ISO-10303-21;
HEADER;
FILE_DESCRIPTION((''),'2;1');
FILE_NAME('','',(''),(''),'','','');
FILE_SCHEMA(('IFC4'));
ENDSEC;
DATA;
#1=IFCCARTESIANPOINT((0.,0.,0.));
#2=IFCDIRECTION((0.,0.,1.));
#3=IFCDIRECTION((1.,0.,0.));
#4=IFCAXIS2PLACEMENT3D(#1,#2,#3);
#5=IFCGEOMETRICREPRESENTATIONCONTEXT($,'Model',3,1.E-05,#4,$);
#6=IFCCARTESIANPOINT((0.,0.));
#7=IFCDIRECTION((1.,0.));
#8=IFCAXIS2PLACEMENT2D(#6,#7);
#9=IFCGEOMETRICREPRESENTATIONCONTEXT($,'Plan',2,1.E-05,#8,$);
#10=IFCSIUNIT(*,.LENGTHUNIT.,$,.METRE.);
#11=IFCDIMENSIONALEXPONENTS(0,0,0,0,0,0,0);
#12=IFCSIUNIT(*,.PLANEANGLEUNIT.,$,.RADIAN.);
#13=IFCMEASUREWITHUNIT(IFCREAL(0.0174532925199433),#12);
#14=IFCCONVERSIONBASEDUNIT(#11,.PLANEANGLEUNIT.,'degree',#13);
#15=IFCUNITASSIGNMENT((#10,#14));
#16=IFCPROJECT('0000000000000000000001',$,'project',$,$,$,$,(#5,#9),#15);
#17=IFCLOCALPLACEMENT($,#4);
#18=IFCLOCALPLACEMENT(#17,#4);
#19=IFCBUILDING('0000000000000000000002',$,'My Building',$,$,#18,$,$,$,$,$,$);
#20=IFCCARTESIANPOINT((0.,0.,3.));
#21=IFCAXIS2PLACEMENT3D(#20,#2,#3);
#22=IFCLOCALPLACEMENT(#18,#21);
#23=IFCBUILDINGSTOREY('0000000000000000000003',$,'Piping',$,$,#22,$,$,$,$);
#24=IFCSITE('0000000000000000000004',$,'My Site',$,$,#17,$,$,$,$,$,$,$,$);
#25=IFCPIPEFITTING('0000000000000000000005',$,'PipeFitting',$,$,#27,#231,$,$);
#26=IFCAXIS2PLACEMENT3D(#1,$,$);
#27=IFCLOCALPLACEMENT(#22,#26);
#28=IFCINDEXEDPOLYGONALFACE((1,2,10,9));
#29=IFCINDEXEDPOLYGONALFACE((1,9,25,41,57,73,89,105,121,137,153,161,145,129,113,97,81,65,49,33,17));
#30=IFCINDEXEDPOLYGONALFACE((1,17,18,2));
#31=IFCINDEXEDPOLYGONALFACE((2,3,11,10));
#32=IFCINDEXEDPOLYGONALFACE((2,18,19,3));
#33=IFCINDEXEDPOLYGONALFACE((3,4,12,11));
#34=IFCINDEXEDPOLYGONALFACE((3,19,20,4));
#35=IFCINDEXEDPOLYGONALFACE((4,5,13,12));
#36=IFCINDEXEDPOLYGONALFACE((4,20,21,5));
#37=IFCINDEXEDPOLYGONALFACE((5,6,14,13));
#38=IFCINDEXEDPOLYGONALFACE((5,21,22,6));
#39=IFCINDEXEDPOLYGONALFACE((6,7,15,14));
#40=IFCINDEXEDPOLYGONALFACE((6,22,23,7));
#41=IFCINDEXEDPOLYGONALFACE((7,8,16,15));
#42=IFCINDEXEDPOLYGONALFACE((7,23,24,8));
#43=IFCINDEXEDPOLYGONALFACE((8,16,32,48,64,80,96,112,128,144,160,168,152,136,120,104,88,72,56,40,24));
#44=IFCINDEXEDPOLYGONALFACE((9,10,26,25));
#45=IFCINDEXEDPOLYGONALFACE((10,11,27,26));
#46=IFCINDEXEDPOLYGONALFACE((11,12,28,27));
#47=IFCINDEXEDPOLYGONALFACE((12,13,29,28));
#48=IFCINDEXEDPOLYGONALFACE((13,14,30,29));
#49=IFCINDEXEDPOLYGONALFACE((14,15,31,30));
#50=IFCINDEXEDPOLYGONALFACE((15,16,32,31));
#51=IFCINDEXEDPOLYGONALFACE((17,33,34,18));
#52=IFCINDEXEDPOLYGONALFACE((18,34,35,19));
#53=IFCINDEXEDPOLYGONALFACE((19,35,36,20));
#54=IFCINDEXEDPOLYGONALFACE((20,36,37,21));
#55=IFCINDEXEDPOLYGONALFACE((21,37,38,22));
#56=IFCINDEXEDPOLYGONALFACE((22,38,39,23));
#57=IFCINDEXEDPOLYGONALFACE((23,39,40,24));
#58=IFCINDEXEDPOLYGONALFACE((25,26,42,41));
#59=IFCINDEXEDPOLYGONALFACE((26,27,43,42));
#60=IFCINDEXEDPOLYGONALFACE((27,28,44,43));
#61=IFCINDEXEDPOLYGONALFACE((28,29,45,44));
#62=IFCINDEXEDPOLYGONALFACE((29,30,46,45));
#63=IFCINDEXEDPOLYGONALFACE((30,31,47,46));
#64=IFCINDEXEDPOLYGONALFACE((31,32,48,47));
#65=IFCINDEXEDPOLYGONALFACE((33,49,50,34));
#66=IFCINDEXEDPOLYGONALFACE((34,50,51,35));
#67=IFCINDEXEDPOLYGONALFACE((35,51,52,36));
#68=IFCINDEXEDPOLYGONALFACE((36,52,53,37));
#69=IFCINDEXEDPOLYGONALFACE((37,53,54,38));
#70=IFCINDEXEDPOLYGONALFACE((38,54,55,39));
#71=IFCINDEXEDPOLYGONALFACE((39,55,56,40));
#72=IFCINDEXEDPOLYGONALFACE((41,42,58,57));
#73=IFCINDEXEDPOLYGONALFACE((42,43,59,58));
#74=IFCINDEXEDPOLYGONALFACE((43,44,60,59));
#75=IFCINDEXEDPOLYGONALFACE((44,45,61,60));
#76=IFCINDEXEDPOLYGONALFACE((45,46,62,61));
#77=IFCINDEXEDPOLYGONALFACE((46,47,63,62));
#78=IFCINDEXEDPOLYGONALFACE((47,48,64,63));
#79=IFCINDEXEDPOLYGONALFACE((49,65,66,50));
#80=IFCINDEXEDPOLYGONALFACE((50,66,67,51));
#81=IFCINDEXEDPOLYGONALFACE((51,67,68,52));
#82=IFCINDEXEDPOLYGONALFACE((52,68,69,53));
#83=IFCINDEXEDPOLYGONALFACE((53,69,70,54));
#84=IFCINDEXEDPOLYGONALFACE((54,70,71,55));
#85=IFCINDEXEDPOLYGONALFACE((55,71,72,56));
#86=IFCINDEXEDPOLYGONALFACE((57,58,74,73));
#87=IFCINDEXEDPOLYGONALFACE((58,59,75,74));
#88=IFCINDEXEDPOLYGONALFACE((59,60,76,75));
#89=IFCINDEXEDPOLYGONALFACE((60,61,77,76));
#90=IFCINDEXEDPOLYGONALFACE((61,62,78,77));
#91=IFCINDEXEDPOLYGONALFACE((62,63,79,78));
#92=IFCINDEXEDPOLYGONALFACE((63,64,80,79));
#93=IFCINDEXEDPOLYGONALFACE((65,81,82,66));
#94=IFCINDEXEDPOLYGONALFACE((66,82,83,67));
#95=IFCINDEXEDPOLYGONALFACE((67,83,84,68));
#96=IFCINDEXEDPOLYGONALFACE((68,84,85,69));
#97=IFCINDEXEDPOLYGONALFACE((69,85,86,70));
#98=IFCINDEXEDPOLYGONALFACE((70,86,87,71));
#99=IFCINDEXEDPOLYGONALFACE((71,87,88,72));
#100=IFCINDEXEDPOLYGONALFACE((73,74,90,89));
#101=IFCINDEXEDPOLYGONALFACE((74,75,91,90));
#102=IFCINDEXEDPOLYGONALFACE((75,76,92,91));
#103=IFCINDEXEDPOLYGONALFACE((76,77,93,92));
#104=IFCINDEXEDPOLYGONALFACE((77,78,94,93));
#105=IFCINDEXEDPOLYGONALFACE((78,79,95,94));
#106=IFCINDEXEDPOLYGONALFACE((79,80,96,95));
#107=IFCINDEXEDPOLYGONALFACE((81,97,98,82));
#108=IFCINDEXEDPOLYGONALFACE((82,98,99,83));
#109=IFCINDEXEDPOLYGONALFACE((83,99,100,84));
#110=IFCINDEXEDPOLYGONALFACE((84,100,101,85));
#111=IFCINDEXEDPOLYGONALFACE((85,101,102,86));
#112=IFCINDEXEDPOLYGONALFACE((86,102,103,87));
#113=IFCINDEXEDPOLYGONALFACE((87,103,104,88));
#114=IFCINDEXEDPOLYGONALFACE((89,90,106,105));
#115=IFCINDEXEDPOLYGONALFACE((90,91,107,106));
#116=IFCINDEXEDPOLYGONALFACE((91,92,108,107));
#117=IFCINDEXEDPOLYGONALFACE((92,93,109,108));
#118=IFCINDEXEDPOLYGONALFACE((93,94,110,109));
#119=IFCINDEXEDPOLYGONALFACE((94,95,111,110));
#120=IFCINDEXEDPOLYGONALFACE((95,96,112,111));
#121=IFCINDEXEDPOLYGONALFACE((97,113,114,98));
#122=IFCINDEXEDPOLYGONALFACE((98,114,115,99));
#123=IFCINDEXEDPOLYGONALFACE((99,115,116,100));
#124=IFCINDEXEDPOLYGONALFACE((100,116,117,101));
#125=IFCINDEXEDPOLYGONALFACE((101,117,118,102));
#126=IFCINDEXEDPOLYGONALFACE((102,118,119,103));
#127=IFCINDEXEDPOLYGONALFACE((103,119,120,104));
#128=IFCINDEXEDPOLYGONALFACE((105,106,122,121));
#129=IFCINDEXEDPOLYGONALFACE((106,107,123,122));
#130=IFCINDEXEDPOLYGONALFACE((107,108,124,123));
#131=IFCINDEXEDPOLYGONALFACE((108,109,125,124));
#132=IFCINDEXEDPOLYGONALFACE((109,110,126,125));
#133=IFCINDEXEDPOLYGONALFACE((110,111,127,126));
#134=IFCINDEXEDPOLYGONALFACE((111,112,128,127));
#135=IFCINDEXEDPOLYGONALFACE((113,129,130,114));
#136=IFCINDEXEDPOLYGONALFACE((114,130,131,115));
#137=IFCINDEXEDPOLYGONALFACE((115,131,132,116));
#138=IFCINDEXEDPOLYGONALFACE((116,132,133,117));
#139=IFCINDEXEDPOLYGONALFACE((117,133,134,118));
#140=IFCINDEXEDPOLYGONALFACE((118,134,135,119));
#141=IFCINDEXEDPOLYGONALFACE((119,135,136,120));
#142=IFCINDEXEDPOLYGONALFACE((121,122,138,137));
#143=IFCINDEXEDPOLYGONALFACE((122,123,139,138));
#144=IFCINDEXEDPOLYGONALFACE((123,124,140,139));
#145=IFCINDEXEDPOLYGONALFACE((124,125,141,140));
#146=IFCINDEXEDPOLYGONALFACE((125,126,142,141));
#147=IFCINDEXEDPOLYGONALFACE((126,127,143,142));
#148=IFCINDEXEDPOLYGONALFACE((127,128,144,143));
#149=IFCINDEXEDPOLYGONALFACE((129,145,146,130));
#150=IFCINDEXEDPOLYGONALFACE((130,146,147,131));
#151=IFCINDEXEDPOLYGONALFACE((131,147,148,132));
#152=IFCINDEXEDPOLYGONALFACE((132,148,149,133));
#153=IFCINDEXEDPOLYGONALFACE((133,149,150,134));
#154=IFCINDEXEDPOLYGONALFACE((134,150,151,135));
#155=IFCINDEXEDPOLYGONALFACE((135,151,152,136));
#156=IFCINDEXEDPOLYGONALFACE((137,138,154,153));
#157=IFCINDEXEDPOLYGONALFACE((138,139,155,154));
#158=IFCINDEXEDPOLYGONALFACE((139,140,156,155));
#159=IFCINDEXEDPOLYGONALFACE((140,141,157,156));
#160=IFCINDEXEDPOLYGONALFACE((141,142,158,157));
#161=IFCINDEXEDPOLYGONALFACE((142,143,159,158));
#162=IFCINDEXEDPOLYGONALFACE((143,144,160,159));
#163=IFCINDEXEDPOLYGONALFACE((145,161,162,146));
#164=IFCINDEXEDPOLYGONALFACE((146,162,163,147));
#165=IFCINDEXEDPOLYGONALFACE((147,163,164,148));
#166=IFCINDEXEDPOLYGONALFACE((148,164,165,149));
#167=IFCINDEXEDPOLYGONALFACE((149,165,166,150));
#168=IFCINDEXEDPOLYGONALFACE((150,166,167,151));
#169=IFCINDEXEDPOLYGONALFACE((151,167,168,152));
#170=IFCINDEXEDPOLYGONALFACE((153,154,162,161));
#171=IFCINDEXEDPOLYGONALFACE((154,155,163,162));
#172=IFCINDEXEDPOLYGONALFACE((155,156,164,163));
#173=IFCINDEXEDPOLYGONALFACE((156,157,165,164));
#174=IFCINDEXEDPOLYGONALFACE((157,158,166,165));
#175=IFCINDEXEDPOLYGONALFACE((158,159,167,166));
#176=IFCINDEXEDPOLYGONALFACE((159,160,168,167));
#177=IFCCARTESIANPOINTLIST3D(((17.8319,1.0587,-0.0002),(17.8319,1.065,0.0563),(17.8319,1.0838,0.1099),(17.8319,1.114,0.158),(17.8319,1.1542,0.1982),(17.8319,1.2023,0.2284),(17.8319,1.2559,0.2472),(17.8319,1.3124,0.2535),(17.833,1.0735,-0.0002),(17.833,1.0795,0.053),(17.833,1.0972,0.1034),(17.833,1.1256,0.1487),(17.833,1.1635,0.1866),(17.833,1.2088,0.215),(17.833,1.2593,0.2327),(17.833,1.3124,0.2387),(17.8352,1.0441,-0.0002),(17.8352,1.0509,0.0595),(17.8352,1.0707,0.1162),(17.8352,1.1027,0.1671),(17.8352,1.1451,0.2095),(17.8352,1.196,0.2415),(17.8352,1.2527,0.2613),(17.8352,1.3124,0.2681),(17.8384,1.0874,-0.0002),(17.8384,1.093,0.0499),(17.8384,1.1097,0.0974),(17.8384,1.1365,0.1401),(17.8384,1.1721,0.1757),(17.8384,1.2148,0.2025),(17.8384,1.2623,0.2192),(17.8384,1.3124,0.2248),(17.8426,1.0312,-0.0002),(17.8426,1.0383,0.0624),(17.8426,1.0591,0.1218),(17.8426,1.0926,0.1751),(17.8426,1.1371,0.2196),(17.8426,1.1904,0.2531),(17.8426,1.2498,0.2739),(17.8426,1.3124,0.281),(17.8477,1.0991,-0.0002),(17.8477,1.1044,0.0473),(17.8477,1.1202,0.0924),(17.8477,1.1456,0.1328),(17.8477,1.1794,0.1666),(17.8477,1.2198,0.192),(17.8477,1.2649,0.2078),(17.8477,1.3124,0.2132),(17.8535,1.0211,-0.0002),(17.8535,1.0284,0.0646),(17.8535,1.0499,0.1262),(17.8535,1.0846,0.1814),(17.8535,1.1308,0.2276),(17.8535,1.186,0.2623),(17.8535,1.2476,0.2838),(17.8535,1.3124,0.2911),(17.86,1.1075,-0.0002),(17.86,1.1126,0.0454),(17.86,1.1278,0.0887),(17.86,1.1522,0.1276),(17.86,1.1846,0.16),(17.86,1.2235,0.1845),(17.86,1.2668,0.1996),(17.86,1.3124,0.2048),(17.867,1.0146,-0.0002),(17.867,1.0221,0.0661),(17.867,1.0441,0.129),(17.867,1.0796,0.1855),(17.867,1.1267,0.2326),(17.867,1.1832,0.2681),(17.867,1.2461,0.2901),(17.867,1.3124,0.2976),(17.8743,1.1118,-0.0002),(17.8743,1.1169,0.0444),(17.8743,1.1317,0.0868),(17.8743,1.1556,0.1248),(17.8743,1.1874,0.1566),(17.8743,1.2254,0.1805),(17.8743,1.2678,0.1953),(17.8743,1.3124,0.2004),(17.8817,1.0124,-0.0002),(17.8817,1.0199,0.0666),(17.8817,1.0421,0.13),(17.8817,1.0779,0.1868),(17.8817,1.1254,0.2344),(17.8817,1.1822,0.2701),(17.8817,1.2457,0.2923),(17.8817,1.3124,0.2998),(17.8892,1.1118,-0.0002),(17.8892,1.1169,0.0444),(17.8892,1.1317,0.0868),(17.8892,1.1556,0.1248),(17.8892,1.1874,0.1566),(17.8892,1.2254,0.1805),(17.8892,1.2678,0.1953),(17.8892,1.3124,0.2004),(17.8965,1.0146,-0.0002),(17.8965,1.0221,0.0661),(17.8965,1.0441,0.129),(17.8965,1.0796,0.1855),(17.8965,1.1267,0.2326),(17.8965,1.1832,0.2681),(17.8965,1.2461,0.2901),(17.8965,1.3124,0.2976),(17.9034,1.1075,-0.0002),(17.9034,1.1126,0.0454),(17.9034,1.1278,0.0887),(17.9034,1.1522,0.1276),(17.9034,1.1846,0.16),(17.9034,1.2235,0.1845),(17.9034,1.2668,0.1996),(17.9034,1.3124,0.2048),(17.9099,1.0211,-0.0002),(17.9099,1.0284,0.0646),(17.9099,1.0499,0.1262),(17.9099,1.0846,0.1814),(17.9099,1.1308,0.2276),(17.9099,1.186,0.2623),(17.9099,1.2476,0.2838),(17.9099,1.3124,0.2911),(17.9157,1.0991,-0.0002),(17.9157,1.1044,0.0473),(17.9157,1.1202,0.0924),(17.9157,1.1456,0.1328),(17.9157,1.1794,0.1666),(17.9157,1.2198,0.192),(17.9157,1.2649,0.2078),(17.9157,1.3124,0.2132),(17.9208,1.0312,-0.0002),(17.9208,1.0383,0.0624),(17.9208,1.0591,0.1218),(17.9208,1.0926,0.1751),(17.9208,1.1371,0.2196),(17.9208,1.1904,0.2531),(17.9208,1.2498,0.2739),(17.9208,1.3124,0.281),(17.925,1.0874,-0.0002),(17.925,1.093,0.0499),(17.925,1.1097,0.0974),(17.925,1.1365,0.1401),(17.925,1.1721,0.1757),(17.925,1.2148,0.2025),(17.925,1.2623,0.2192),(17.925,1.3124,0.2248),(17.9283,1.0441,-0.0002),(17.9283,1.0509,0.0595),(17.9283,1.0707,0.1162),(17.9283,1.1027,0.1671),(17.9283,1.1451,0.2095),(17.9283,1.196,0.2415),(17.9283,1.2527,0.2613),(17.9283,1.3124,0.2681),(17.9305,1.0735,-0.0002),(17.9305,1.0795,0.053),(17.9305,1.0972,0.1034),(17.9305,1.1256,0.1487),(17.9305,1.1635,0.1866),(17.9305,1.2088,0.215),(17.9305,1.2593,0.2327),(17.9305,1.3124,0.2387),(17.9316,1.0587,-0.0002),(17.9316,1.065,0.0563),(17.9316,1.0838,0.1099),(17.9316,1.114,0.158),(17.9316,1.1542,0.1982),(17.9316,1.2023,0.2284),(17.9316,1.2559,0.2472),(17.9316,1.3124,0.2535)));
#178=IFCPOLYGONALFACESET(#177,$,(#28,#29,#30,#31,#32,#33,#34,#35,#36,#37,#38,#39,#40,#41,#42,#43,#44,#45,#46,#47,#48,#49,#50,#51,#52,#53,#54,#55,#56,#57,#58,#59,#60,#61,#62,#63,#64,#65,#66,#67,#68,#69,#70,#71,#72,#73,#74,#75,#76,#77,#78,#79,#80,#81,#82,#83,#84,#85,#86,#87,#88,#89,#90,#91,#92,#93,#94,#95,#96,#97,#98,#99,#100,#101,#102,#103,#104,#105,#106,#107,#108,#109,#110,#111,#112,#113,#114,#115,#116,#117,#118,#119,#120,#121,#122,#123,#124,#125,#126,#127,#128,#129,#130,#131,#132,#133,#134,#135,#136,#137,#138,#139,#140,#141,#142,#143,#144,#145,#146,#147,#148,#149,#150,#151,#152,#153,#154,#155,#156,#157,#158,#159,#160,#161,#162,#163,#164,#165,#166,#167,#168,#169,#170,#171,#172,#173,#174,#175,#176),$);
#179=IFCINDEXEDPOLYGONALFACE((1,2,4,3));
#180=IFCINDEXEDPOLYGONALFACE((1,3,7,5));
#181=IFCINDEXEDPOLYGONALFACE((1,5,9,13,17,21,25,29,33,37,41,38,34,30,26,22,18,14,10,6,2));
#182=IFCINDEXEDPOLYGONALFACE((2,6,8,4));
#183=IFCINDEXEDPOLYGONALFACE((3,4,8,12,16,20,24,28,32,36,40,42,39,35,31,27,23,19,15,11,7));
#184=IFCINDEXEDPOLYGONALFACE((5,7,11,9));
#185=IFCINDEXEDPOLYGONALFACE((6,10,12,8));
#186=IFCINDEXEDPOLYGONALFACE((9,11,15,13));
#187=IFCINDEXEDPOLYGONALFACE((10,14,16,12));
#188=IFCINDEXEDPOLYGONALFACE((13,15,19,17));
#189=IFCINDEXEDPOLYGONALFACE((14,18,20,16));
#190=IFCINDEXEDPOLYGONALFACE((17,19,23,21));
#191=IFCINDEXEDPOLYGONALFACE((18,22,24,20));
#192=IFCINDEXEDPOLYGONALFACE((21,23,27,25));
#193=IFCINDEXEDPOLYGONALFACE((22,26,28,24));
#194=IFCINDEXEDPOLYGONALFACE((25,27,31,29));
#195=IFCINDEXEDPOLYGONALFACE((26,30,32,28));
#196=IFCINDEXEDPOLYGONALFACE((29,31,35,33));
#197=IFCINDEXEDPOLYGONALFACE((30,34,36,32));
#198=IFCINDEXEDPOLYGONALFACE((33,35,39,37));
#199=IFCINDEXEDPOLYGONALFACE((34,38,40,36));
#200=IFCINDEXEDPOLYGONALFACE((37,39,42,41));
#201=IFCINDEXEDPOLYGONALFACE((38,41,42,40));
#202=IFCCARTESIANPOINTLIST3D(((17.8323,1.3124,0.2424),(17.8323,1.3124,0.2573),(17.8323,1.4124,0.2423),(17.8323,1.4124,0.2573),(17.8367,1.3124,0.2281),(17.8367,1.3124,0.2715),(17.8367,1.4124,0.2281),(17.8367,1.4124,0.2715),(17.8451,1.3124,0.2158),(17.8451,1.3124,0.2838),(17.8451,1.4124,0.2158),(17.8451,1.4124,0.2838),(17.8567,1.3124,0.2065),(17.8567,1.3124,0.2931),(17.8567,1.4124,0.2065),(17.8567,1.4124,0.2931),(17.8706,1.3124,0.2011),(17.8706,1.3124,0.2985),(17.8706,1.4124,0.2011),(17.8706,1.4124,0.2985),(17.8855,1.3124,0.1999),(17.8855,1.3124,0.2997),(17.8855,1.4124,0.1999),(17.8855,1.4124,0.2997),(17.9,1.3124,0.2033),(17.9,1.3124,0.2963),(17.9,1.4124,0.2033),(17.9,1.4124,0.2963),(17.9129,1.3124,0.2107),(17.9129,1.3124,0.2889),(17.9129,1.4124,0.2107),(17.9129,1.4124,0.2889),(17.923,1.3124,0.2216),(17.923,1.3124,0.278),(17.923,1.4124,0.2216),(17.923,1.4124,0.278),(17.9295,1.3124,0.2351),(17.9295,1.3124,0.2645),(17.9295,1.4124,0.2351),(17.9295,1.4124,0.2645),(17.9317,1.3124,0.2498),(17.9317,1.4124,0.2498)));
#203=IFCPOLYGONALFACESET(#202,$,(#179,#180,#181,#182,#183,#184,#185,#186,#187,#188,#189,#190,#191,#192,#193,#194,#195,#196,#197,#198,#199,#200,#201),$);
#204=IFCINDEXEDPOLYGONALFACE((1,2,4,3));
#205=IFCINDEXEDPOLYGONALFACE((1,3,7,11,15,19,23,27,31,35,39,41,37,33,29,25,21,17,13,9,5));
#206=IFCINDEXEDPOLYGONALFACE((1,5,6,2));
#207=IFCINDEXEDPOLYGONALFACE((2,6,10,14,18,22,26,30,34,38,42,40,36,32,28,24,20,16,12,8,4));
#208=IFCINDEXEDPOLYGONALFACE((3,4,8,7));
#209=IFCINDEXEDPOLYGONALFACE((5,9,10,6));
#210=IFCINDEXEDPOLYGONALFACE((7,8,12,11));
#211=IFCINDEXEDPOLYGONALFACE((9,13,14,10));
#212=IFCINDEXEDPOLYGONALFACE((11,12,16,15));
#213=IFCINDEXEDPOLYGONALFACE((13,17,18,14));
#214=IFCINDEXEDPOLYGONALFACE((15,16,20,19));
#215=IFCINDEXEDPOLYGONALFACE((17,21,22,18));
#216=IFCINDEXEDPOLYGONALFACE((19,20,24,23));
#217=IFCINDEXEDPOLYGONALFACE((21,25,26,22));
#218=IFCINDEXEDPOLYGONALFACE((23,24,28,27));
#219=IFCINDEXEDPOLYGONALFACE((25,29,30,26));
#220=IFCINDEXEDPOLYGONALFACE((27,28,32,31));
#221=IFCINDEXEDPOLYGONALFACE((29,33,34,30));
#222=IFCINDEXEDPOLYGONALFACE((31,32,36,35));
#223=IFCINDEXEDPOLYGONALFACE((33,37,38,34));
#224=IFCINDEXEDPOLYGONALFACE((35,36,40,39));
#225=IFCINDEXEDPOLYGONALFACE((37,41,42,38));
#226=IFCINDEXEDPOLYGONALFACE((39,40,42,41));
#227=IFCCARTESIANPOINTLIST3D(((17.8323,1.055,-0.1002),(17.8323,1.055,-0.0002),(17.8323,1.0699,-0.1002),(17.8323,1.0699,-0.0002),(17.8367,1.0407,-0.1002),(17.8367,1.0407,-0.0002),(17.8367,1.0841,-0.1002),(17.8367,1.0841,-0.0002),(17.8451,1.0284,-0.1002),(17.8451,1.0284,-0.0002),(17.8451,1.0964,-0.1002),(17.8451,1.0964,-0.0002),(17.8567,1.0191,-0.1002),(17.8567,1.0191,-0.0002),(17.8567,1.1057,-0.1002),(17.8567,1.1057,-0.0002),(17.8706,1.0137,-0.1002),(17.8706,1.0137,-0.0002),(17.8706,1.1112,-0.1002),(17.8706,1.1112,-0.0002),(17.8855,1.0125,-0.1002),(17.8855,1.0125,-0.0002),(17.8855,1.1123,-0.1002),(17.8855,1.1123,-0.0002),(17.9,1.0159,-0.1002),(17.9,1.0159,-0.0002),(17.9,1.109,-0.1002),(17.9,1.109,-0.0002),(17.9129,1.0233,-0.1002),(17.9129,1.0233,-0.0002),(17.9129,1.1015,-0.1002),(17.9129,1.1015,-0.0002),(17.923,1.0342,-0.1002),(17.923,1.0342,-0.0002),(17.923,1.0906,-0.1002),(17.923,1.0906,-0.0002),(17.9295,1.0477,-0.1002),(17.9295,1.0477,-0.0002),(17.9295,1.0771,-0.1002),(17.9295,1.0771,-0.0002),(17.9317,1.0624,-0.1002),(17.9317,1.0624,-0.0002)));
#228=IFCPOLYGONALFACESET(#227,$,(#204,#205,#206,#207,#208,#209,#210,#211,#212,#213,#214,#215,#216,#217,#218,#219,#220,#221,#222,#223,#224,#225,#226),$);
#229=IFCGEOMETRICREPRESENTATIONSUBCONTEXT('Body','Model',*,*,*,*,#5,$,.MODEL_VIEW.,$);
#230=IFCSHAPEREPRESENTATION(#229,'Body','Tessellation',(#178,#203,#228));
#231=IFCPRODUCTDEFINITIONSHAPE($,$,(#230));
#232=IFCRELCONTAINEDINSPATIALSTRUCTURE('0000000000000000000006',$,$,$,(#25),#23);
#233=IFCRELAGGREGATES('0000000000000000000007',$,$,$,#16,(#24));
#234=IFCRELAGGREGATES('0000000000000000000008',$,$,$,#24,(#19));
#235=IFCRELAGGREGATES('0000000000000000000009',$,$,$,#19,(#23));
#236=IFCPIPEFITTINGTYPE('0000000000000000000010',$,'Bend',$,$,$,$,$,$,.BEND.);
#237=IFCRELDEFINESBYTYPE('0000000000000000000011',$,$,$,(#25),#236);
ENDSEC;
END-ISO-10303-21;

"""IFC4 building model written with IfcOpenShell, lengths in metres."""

from ifc_helpers import new_model, entity, si_unit, converted_unit, frame, origin_with_axes, origin_2d_with_axis, place, context, subcontext, project, spatial, circle, extrude, source, transform, mapped, type_object, type_shapes, element, save


model = new_model("IFC4")

# Units and contexts
model_context = context("Model", 3, precision=1e-05, world=origin_with_axes())
plan_context = context("Plan", 2, precision=1e-05, world=origin_2d_with_axis())
body_context = subcontext(model_context, "Body", "Model", "MODEL_VIEW")
ifc_project = project(units=[si_unit("LENGTHUNIT", "METRE"), converted_unit("PLANEANGLEUNIT", "degree", entity("IfcReal", 0.0174532925199433), si_unit("PLANEANGLEUNIT", "RADIAN"), dimensions=[0, 0, 0, 0, 0, 0, 0])], contexts=[model_context, plan_context])

# Site, building, storey
site_placement = place(None, origin_with_axes())
site = spatial("IfcSite", under=ifc_project, at=site_placement, Name="My Site")
building_placement = place(site_placement, origin_with_axes())
building = spatial("IfcBuilding", under=site, at=building_placement, Name="My Building")
storey_placement = place(building_placement, frame((0.0, 0.0, 3.0), z_axis=(0.0, 0.0, 1.0), x_axis=(1.0, 0.0, 0.0)))
storey = spatial("IfcBuildingStorey", under=building, at=storey_placement, Name="Piping")

# Pipe fitting
pipe_fitting_type_1 = type_object("IfcPipeFittingType", Name="Bend", PredefinedType="BEND")
shared_shape = source(origin_with_axes(), body_context, "Body", "SolidModel", [
    entity("IfcSweptDiskSolid", entity("IfcIndexedPolyCurve", entity("IfcCartesianPointList3D", [[0.0, 0.0, 0.1], [0.0, -0.0732, 0.2768], [0.0, -0.25, 0.35]]), [entity("IfcArcIndex", [1, 2, 3])]), 0.05),
    extrude(circle(Radius=0.05), origin_with_axes(), (0.0, 0.0, 1.0), 0.1),
    extrude(circle(Radius=0.05), frame((0.0, -0.25, 0.35), z_axis=(0.0, -1.0, -0.00003), x_axis=(1.0, 0.0, 0.0)), (0.0, 0.0, 1.0), 0.1),
])
type_shapes(pipe_fitting_type_1, [shared_shape])
for number, where, z_axis, x_axis, name in (
    (1, (17.8817, 1.4124, 0.2498), (0.0, -1.0, 0.000008), (1.0, 0.0, 0.0), "PipeFitting"),
):
    element("IfcPipeFitting", number, at=place(storey_placement, frame(where, z_axis=z_axis, x_axis=x_axis)), inside=storey, type_object=pipe_fitting_type_1, Name=name, context=body_context, shape_type="MappedRepresentation", body=[
        mapped(shared_shape, transform((0.0, 0.0, 0.0), x_axis=(1.0, 0.0, 0.0), y_axis=(0.0, 1.0, 0.0), z_axis=(0.0, 0.0, 1.0), scale=1.0)),
    ])

save(model, "model.ifc")
